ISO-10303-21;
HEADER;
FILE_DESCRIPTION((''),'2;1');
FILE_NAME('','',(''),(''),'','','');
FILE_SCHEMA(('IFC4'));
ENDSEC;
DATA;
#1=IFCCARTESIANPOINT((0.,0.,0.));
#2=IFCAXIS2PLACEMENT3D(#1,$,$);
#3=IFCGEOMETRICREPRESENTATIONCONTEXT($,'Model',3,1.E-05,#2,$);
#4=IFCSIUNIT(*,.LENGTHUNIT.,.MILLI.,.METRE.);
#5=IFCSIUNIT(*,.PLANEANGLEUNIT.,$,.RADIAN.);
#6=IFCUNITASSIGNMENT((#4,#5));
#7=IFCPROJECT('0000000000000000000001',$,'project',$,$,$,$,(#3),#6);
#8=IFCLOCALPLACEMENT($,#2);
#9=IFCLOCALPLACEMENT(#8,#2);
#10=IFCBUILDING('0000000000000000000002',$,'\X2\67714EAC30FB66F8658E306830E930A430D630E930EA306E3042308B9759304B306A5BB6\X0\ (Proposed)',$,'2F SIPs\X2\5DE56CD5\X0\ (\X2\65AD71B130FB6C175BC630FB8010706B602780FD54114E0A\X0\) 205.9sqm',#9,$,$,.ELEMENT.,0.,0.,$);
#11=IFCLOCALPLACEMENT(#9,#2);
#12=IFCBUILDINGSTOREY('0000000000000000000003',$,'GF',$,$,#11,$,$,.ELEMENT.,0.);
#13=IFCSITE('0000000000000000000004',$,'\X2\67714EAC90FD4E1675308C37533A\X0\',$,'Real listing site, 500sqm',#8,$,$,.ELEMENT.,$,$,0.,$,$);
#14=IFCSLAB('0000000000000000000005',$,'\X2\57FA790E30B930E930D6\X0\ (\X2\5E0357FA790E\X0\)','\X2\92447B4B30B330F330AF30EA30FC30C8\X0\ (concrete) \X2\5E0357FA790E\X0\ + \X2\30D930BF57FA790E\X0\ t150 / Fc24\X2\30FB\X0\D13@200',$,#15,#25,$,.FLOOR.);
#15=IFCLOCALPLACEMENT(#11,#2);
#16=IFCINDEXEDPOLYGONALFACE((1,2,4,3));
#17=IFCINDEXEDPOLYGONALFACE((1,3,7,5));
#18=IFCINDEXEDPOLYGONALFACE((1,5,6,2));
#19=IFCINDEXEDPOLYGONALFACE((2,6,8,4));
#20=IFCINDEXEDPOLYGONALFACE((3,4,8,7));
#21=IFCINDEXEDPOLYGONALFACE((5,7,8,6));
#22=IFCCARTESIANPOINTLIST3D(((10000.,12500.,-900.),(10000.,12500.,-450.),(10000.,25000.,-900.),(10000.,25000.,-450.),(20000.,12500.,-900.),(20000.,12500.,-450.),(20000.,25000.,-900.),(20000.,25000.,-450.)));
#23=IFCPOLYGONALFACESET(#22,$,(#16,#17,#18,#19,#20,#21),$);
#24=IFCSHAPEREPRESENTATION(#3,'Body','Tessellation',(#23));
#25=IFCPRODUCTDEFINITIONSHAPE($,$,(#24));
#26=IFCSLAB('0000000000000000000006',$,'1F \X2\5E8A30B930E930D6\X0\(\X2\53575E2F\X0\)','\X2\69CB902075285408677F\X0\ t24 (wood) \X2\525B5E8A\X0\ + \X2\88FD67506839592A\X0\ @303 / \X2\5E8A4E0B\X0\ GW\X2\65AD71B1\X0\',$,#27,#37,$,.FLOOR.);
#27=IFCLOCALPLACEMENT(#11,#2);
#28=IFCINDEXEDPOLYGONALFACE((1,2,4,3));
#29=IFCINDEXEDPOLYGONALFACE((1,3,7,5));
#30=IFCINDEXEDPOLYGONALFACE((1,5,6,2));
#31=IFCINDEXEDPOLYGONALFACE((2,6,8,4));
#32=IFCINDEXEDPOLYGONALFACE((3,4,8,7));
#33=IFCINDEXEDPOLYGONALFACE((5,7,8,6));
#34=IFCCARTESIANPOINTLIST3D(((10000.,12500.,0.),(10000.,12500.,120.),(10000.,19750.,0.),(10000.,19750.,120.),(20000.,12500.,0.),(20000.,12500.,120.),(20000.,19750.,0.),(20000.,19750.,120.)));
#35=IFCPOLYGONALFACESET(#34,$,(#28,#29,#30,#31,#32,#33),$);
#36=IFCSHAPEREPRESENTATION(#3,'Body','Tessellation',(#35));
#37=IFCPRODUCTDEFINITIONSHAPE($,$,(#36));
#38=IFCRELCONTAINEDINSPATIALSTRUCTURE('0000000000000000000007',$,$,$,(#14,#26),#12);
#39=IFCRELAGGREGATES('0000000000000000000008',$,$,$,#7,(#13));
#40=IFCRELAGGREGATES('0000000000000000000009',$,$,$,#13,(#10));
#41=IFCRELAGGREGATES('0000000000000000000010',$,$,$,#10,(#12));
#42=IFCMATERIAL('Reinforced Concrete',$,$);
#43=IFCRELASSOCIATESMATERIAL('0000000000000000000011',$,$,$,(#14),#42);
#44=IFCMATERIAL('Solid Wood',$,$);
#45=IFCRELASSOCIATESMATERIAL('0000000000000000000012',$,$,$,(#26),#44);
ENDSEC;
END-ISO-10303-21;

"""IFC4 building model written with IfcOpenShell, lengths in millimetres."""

from ifc_helpers import new_model, si_unit, frame, frame_2d, origin, place, context, project, spatial, rectangle, extrude, material, element, save


model = new_model("IFC4")

# Units and contexts
model_context = context("Model", 3, precision=1e-05, world=origin())
ifc_project = project(units=[si_unit("LENGTHUNIT", "METRE", prefix="MILLI"), si_unit("PLANEANGLEUNIT", "RADIAN")], contexts=[model_context])

# Site, building, storey
site_placement = place(None, origin())
site = spatial("IfcSite", under=ifc_project, at=site_placement, Name="東京都世田谷区", ObjectType="Real listing site, 500sqm", CompositionType="ELEMENT", RefElevation=0.0)
building_placement = place(site_placement, origin())
building = spatial("IfcBuilding", under=site, at=building_placement, Name="東京・書斎とライブラリのある静かな家 (Proposed)", ObjectType="2F SIPs工法 (断熱・気密・耐火性能向上) 205.9sqm", CompositionType="ELEMENT", ElevationOfRefHeight=0.0, ElevationOfTerrain=0.0)
storey_placement = place(building_placement, origin())
storey = spatial("IfcBuildingStorey", under=building, at=storey_placement, Name="GF", CompositionType="ELEMENT", Elevation=0.0)

# Shared definitions
ifc_material_1 = material(Name="Solid Wood")

# Slabs
ifc_material_2 = material(Name="Reinforced Concrete")
slab_1_placement = place(storey_placement, frame((5000.0, 6250.0, -450.0)))
element("IfcSlab", 1, at=slab_1_placement, inside=storey, material=ifc_material_2, Name="基礎スラブ (布基礎)", Description="鉄筋コンクリート (concrete) 布基礎 + ベタ基礎 t150 / Fc24・D13@200", PredefinedType="FLOOR", context=model_context, shape_type="SweptSolid", body=[
    extrude(rectangle(XDim=10000.0, YDim=12500.0, at=frame_2d((5000.0, 6250.0))), frame((5000.0, 6250.0, -450.0)), (0.0, 0.0, 1.0), 450.0),
])
slab_2_placement = place(storey_placement, frame((5000.0, 6250.0, 0.0)))
element("IfcSlab", 2, at=slab_2_placement, inside=storey, material=ifc_material_1, Name="1F 床スラブ(南帯)", Description="構造用合板 t24 (wood) 剛床 + 製材根太 @303 / 床下 GW断熱", PredefinedType="FLOOR", context=model_context, shape_type="SweptSolid", body=[
    extrude(rectangle(XDim=10000.0, YDim=7250.0, at=frame_2d((5000.0, 3625.0))), frame((5000.0, 6250.0, 0.0)), (0.0, 0.0, 1.0), 120.0),
])

save(model, "model.ifc")
